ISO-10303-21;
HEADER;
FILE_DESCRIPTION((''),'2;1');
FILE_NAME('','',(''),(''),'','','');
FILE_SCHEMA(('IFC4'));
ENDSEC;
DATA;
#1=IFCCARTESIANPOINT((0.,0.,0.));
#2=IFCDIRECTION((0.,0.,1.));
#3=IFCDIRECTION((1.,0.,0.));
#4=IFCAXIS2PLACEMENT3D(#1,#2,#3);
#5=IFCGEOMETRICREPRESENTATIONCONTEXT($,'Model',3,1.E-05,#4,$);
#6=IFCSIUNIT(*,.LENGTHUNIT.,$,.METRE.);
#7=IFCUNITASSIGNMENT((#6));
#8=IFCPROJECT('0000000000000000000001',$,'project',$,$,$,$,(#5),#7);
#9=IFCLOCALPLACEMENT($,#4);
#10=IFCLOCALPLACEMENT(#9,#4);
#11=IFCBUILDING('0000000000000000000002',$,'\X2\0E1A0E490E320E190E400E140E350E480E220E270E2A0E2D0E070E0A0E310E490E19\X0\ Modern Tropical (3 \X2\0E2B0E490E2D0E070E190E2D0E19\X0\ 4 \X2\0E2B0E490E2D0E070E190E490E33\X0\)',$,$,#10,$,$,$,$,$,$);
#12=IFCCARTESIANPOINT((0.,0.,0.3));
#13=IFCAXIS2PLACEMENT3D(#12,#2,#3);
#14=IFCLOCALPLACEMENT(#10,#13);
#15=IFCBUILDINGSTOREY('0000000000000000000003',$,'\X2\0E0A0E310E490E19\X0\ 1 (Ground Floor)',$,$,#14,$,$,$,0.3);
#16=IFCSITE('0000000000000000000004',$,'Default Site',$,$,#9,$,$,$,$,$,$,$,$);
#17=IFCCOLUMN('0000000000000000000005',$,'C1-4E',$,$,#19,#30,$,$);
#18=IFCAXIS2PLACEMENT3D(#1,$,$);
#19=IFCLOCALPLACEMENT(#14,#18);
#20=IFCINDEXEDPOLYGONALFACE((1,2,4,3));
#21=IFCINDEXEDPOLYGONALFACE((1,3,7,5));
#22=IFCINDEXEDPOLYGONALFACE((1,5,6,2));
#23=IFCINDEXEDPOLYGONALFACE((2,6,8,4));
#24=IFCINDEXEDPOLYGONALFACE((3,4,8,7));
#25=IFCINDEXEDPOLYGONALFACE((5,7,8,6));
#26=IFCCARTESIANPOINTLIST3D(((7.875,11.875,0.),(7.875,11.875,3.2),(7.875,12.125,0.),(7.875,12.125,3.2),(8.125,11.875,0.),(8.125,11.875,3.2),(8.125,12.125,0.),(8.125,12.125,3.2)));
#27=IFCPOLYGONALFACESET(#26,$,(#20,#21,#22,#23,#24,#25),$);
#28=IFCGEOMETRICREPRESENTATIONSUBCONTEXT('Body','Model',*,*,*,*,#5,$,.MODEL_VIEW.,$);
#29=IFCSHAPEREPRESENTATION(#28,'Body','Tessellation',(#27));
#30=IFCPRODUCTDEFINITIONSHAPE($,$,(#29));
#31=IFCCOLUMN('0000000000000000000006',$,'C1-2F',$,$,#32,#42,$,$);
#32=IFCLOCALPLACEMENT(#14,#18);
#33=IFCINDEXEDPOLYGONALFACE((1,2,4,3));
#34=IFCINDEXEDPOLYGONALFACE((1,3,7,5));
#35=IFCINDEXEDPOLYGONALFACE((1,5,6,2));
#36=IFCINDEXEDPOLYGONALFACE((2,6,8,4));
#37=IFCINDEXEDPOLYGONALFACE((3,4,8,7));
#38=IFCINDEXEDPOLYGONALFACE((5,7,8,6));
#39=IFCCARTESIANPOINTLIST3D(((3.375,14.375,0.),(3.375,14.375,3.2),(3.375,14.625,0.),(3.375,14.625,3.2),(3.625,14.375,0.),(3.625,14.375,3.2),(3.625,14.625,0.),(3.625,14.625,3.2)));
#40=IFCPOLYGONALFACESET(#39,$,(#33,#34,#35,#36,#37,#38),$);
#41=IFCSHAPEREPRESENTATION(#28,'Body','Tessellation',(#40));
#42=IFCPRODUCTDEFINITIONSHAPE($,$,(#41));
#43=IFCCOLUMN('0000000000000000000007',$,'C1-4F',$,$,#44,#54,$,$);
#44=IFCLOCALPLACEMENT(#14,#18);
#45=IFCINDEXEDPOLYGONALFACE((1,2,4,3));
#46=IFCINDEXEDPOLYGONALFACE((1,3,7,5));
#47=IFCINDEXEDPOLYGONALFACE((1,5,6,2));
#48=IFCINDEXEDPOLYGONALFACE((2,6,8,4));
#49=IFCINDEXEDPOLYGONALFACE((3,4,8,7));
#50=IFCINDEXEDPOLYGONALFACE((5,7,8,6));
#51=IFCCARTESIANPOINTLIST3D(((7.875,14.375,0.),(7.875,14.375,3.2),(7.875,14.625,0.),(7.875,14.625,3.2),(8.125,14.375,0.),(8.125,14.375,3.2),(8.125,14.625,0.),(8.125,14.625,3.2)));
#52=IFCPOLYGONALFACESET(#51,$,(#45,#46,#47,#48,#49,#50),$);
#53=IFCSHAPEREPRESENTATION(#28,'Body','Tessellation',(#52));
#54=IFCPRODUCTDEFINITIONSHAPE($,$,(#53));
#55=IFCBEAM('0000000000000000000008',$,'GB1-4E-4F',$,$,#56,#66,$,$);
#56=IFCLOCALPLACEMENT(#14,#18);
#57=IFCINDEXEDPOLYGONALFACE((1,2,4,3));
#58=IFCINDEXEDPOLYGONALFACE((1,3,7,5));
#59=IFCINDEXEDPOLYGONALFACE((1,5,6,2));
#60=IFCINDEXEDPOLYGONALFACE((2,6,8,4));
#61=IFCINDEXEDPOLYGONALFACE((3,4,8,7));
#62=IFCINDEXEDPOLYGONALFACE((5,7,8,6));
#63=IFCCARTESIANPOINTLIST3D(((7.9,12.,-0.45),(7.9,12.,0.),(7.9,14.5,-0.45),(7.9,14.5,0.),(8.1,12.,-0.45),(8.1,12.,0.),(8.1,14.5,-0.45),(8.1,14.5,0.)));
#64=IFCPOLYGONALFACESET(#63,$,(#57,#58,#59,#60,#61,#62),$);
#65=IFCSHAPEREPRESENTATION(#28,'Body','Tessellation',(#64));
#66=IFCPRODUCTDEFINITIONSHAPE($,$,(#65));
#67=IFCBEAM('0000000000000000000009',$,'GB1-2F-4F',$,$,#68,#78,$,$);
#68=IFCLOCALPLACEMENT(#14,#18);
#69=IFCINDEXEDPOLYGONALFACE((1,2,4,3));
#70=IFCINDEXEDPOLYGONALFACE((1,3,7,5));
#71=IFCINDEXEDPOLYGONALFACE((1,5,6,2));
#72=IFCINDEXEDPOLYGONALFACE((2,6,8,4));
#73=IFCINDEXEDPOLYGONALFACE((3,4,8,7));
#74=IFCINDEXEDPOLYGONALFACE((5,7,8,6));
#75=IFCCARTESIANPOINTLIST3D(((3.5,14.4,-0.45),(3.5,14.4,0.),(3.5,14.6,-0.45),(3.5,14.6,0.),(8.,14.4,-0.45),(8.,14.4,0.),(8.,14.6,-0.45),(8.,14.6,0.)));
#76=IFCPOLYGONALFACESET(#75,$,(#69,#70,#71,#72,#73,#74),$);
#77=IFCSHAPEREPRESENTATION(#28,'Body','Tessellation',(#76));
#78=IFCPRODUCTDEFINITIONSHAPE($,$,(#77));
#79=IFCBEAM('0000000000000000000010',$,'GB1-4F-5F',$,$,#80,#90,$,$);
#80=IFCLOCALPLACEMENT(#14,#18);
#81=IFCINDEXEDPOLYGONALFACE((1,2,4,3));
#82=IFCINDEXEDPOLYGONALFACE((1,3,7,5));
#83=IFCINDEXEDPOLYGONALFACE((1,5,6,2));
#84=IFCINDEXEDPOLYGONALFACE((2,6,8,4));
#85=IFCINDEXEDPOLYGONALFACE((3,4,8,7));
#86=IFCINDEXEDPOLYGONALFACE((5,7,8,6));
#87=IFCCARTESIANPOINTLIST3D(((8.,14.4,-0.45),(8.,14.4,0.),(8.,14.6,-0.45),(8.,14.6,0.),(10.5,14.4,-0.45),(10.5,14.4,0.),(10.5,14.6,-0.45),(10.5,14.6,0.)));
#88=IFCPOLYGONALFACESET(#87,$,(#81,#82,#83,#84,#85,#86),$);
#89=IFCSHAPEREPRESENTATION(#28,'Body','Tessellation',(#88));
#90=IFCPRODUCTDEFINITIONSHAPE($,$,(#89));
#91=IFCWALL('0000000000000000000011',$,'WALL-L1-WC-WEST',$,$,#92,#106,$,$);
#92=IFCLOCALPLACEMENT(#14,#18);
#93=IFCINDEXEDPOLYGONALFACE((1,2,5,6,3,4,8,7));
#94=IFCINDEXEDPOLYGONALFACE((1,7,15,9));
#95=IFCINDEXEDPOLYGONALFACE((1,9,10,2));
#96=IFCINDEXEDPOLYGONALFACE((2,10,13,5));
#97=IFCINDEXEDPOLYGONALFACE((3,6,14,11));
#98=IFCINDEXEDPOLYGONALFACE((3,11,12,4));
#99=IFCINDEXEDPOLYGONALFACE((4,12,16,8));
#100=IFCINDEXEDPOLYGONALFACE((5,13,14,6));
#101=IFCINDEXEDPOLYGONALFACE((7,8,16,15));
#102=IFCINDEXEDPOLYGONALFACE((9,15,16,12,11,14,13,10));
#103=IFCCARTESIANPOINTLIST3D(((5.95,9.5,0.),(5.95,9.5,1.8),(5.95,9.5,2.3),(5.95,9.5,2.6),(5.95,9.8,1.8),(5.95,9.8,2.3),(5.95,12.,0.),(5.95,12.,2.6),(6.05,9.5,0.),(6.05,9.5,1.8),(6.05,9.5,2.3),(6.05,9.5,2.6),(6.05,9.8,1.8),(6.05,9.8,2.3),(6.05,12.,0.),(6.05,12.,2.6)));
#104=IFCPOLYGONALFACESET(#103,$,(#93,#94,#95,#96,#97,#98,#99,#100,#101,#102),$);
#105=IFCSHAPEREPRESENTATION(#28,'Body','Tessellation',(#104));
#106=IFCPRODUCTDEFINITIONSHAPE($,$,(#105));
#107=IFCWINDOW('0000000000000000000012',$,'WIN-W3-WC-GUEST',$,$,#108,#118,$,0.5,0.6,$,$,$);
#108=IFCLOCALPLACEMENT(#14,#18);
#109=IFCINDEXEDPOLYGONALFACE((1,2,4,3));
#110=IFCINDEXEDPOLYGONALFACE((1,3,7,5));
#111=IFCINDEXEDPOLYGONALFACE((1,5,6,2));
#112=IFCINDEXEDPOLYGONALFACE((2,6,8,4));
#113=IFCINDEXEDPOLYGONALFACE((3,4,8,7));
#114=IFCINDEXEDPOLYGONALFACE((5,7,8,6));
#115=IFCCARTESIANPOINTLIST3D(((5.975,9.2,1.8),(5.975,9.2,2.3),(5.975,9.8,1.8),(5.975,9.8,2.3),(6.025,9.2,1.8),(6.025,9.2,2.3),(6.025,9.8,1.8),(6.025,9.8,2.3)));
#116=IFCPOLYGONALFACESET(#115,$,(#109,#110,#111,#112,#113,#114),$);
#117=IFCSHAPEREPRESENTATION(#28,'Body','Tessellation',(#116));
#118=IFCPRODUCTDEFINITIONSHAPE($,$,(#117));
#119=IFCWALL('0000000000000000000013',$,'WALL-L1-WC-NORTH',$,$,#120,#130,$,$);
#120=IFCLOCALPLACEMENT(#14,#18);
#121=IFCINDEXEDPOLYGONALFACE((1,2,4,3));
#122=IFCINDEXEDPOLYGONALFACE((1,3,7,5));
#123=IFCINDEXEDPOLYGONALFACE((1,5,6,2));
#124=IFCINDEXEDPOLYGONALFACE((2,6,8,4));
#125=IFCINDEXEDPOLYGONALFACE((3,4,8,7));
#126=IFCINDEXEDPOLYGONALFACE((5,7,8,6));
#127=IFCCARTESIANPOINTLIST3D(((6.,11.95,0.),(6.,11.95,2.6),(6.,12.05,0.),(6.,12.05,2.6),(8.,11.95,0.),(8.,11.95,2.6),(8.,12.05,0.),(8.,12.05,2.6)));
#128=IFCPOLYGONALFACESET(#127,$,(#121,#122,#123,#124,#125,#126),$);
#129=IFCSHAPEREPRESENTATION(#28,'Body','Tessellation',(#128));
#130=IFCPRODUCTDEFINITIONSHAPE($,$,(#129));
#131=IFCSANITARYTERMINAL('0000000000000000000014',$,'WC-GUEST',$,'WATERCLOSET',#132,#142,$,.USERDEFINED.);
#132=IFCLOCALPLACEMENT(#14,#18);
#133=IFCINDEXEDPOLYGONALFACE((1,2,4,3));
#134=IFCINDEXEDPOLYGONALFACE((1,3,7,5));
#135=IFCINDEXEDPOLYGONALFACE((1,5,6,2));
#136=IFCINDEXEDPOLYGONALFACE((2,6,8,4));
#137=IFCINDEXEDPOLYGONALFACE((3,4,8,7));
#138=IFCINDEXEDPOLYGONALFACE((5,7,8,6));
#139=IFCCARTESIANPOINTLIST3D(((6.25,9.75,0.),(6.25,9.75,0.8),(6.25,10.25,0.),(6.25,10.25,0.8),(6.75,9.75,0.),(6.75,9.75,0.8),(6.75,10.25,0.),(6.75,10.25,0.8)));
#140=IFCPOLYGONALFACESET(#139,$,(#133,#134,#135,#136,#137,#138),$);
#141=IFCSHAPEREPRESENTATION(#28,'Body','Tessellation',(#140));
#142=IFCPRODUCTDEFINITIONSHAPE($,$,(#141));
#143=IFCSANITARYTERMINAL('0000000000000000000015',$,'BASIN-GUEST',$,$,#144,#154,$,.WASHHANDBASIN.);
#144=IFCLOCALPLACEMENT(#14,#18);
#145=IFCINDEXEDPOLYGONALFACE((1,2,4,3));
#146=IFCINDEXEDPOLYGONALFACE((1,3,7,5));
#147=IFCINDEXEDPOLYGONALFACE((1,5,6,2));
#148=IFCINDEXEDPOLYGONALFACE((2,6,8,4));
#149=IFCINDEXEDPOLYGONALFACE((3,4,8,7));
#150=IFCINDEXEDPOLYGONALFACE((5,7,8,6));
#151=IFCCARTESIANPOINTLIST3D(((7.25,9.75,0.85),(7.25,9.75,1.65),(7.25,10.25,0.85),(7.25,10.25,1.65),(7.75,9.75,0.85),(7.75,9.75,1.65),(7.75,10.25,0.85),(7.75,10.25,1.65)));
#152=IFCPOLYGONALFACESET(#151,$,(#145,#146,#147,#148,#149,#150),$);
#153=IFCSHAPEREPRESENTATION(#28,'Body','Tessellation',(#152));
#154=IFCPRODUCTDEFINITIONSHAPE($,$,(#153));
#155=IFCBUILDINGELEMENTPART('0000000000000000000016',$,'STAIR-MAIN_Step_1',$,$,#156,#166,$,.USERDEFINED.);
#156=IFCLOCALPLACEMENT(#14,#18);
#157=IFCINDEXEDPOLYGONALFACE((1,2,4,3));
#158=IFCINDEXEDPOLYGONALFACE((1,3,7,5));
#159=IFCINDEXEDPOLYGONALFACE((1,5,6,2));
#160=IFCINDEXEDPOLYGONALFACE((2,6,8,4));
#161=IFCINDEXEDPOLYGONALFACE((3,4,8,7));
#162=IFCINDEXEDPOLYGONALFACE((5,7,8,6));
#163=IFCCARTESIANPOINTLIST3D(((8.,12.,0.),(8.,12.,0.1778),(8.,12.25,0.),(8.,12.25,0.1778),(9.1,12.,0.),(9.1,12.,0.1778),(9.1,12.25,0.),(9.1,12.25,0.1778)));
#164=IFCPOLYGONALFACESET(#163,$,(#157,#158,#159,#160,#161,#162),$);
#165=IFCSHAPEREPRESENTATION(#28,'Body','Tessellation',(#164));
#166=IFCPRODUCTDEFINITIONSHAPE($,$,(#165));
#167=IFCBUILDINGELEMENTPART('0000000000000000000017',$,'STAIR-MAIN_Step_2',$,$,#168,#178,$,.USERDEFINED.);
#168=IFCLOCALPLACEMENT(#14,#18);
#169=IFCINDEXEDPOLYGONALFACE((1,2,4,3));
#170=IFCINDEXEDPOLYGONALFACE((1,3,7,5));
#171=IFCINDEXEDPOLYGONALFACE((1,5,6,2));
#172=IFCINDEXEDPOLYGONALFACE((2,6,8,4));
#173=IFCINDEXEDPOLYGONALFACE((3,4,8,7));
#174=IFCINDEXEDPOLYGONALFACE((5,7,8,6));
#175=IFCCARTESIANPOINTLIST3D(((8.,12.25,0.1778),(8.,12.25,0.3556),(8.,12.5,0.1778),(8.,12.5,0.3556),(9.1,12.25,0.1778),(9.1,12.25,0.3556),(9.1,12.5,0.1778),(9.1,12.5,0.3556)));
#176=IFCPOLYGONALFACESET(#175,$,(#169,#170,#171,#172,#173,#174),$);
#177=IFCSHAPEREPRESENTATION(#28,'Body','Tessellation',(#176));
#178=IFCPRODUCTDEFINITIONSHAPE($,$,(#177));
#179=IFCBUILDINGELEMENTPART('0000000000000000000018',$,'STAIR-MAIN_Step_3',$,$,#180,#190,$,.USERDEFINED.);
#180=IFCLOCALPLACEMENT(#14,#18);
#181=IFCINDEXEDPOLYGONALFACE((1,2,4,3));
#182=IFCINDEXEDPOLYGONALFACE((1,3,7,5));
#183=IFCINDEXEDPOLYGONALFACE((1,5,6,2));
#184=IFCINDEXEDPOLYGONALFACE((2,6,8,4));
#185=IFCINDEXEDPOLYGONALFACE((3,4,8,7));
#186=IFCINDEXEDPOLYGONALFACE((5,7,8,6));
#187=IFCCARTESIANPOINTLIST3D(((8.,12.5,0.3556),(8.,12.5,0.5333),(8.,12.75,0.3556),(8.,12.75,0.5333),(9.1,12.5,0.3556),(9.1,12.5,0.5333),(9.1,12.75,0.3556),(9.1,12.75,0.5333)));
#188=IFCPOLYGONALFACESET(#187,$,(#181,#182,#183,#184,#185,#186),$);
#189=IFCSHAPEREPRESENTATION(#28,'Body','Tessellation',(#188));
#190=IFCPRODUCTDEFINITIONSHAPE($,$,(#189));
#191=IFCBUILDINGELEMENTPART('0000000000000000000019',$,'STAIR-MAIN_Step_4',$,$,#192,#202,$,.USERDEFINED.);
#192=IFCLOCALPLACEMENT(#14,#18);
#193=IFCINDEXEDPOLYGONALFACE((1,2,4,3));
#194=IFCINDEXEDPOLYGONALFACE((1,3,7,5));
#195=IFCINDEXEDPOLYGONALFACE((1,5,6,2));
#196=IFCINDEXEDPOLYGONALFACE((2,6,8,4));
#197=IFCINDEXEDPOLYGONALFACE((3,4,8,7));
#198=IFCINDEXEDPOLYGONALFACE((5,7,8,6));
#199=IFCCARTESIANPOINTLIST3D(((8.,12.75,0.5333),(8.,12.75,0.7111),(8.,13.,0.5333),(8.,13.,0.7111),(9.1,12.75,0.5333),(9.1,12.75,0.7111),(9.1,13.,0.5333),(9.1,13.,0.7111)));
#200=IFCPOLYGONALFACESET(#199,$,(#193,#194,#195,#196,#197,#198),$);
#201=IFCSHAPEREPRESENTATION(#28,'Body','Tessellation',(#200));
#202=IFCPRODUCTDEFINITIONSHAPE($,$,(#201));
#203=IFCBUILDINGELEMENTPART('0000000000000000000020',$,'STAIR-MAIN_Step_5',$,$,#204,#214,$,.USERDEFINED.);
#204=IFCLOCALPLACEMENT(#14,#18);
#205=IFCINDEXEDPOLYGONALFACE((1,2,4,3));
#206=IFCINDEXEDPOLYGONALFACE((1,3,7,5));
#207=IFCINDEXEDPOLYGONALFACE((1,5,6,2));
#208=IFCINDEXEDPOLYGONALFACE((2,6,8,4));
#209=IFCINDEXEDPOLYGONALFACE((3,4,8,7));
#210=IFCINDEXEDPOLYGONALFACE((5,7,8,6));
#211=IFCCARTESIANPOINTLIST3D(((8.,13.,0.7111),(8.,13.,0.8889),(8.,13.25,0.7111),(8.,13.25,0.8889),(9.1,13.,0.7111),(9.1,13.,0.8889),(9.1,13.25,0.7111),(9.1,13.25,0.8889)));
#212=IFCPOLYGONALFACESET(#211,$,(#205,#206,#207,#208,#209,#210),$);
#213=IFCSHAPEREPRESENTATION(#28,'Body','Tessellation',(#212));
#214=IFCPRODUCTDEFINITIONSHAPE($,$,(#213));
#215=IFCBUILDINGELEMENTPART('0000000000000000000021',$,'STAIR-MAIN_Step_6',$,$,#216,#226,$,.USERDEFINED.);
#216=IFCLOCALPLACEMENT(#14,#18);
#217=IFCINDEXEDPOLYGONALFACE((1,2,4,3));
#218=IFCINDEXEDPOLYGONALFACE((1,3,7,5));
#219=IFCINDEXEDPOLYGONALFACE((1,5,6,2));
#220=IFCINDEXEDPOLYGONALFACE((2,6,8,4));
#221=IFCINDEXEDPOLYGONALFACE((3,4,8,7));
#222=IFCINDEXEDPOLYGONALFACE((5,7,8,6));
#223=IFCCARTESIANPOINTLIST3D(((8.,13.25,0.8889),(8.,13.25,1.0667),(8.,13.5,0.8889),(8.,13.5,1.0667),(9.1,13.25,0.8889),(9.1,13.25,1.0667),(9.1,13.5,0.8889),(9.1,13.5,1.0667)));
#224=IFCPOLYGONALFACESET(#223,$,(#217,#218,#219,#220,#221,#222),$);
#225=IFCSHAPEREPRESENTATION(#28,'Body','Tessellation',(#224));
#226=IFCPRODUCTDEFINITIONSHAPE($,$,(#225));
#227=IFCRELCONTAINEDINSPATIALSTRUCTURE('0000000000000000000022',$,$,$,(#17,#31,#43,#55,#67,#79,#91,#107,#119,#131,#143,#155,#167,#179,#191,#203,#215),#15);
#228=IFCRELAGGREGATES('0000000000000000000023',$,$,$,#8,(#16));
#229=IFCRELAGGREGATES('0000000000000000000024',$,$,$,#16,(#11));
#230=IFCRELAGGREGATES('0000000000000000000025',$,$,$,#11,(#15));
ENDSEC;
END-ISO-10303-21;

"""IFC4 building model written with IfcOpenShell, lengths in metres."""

from ifc_helpers import new_model, si_unit, frame, origin_with_axes, origin_2d, place, context, subcontext, project, spatial, rectangle, extrude, element, fill, save


model = new_model("IFC4")

# Units and contexts
model_context = context("Model", 3, precision=1e-05, world=origin_with_axes())
body_context = subcontext(model_context, "Body", "Model", "MODEL_VIEW")
ifc_project = project(units=[si_unit("LENGTHUNIT", "METRE")], contexts=[model_context])

# Site, building, storey
site_placement = place(None, origin_with_axes())
site = spatial("IfcSite", under=ifc_project, at=site_placement, Name="Default Site")
building_placement = place(site_placement, origin_with_axes())
building = spatial("IfcBuilding", under=site, at=building_placement, Name="บ้านเดี่ยวสองชั้น Modern Tropical (3 ห้องนอน 4 ห้องน้ำ)")
storey_placement = place(building_placement, frame((0.0, 0.0, 0.3), z_axis=(0.0, 0.0, 1.0), x_axis=(1.0, 0.0, 0.0)))
storey = spatial("IfcBuildingStorey", under=building, at=storey_placement, Name="ชั้น 1 (Ground Floor)", Elevation=0.3)

# Columns
for number, where, z_axis, x_axis, name in (
    (1, (8.0, 12.0, 0.0), (0.0, 0.0, 1.0), (1.0, 0.0, 0.0), "C1-4E"),
    (2, (3.5, 14.5, 0.0), (0.0, 0.0, 1.0), (1.0, 0.0, 0.0), "C1-2F"),
    (3, (8.0, 14.5, 0.0), (0.0, 0.0, 1.0), (1.0, 0.0, 0.0), "C1-4F"),
):
    element("IfcColumn", number, at=place(storey_placement, frame(where, z_axis=z_axis, x_axis=x_axis)), inside=storey, Name=name, context=body_context, shape_type="SweptSolid", body=[
        extrude(rectangle(XDim=0.25, YDim=0.25, at=origin_2d()), origin_with_axes(), (0.0, 0.0, 1.0), 3.2),
    ])

# Beams
beam_1_placement = place(storey_placement, frame((8.0, 12.0, -0.225), z_axis=(0.0, 1.0, 0.0), x_axis=(-1.0, 0.0, 0.0)))
element("IfcBeam", 4, at=beam_1_placement, inside=storey, Name="GB1-4E-4F", context=body_context, shape_type="SweptSolid", body=[
    extrude(rectangle(XDim=0.2, YDim=0.45, at=origin_2d()), origin_with_axes(), (0.0, 0.0, 1.0), 2.5),
])
beam_2_placement = place(storey_placement, frame((3.5, 14.5, -0.225), z_axis=(1.0, 0.0, 0.0), x_axis=(0.0, 1.0, 0.0)))
element("IfcBeam", 5, at=beam_2_placement, inside=storey, Name="GB1-2F-4F", context=body_context, shape_type="SweptSolid", body=[
    extrude(rectangle(XDim=0.2, YDim=0.45, at=origin_2d()), origin_with_axes(), (0.0, 0.0, 1.0), 4.5),
])
beam_3_placement = place(storey_placement, frame((8.0, 14.5, -0.225), z_axis=(1.0, 0.0, 0.0), x_axis=(0.0, 1.0, 0.0)))
element("IfcBeam", 6, at=beam_3_placement, inside=storey, Name="GB1-4F-5F", context=body_context, shape_type="SweptSolid", body=[
    extrude(rectangle(XDim=0.2, YDim=0.45, at=origin_2d()), origin_with_axes(), (0.0, 0.0, 1.0), 2.5),
])

# Wall, opening, window
wall_1_placement = place(storey_placement, frame((6.0, 10.75, 0.0), z_axis=(0.0, 0.0, 1.0), x_axis=(0.0, 1.0, 0.0)))
wall_1 = element("IfcWall", 7, at=wall_1_placement, inside=storey, Name="WALL-L1-WC-WEST", context=body_context, shape_type="SweptSolid", body=[
    extrude(rectangle(XDim=2.5, YDim=0.1, at=origin_2d()), origin_with_axes(), (0.0, 0.0, 1.0), 2.6),
])
opening_placement = place(wall_1_placement, frame((-1.25, 0.0, 1.8), z_axis=(0.0, 0.0, 1.0), x_axis=(1.0, 0.0, 0.0)))
opening = element("IfcOpeningElement", 8, at=opening_placement, cuts=wall_1, context=body_context, shape_type="SweptSolid", body=[
    extrude(rectangle(XDim=0.6, YDim=0.12, at=origin_2d()), origin_with_axes(), (0.0, 0.0, 1.0), 0.5),
])
window_placement = place(opening_placement, origin_with_axes())
window = element("IfcWindow", 9, at=window_placement, inside=storey, Name="WIN-W3-WC-GUEST", OverallHeight=0.5, OverallWidth=0.6, context=body_context, shape_type="SweptSolid", body=[
    extrude(rectangle(XDim=0.6, YDim=0.05, at=origin_2d()), origin_with_axes(), (0.0, 0.0, 1.0), 0.5),
])
fill(opening, window)

# Wall
wall_2_placement = place(storey_placement, frame((7.0, 12.0, 0.0), z_axis=(0.0, 0.0, 1.0), x_axis=(1.0, 0.0, 0.0)))
element("IfcWall", 10, at=wall_2_placement, inside=storey, Name="WALL-L1-WC-NORTH", context=body_context, shape_type="SweptSolid", body=[
    extrude(rectangle(XDim=2.0, YDim=0.1, at=origin_2d()), origin_with_axes(), (0.0, 0.0, 1.0), 2.6),
])

# Sanitary terminals
sanitary_terminal_1_placement = place(storey_placement, frame((6.5, 10.0, 0.0), z_axis=(0.0, 0.0, 1.0), x_axis=(1.0, 0.0, 0.0)))
element("IfcSanitaryTerminal", 11, at=sanitary_terminal_1_placement, inside=storey, Name="WC-GUEST", ObjectType="WATERCLOSET", PredefinedType="USERDEFINED", context=body_context, shape_type="SweptSolid", body=[
    extrude(rectangle(XDim=0.5, YDim=0.5, at=origin_2d()), origin_with_axes(), (0.0, 0.0, 1.0), 0.8),
])
sanitary_terminal_2_placement = place(storey_placement, frame((7.5, 10.0, 0.85), z_axis=(0.0, 0.0, 1.0), x_axis=(1.0, 0.0, 0.0)))
element("IfcSanitaryTerminal", 12, at=sanitary_terminal_2_placement, inside=storey, Name="BASIN-GUEST", PredefinedType="WASHHANDBASIN", context=body_context, shape_type="SweptSolid", body=[
    extrude(rectangle(XDim=0.5, YDim=0.5, at=origin_2d()), origin_with_axes(), (0.0, 0.0, 1.0), 0.8),
])

# Building element parts
for number, where, z_axis, x_axis, name in (
    (13, (8.55, 12.125, 0.0), (0.0, 0.0, 1.0), (1.0, 0.0, 0.0), "STAIR-MAIN_Step_1"),
    (14, (8.55, 12.375, 0.1778), (0.0, 0.0, 1.0), (1.0, 0.0, 0.0), "STAIR-MAIN_Step_2"),
    (15, (8.55, 12.625, 0.3556), (0.0, 0.0, 1.0), (1.0, 0.0, 0.0), "STAIR-MAIN_Step_3"),
    (16, (8.55, 12.875, 0.5333), (0.0, 0.0, 1.0), (1.0, 0.0, 0.0), "STAIR-MAIN_Step_4"),
    (17, (8.55, 13.125, 0.7111), (0.0, 0.0, 1.0), (1.0, 0.0, 0.0), "STAIR-MAIN_Step_5"),
    (18, (8.55, 13.375, 0.8889), (0.0, 0.0, 1.0), (1.0, 0.0, 0.0), "STAIR-MAIN_Step_6"),
):
    element("IfcBuildingElementPart", number, at=place(storey_placement, frame(where, z_axis=z_axis, x_axis=x_axis)), inside=storey, Name=name, PredefinedType="USERDEFINED", context=body_context, shape_type="SweptSolid", body=[
        extrude(rectangle(XDim=1.1, YDim=0.25, at=origin_2d()), origin_with_axes(), (0.0, 0.0, 1.0), 0.1778),
    ])

save(model, "model.ifc")
